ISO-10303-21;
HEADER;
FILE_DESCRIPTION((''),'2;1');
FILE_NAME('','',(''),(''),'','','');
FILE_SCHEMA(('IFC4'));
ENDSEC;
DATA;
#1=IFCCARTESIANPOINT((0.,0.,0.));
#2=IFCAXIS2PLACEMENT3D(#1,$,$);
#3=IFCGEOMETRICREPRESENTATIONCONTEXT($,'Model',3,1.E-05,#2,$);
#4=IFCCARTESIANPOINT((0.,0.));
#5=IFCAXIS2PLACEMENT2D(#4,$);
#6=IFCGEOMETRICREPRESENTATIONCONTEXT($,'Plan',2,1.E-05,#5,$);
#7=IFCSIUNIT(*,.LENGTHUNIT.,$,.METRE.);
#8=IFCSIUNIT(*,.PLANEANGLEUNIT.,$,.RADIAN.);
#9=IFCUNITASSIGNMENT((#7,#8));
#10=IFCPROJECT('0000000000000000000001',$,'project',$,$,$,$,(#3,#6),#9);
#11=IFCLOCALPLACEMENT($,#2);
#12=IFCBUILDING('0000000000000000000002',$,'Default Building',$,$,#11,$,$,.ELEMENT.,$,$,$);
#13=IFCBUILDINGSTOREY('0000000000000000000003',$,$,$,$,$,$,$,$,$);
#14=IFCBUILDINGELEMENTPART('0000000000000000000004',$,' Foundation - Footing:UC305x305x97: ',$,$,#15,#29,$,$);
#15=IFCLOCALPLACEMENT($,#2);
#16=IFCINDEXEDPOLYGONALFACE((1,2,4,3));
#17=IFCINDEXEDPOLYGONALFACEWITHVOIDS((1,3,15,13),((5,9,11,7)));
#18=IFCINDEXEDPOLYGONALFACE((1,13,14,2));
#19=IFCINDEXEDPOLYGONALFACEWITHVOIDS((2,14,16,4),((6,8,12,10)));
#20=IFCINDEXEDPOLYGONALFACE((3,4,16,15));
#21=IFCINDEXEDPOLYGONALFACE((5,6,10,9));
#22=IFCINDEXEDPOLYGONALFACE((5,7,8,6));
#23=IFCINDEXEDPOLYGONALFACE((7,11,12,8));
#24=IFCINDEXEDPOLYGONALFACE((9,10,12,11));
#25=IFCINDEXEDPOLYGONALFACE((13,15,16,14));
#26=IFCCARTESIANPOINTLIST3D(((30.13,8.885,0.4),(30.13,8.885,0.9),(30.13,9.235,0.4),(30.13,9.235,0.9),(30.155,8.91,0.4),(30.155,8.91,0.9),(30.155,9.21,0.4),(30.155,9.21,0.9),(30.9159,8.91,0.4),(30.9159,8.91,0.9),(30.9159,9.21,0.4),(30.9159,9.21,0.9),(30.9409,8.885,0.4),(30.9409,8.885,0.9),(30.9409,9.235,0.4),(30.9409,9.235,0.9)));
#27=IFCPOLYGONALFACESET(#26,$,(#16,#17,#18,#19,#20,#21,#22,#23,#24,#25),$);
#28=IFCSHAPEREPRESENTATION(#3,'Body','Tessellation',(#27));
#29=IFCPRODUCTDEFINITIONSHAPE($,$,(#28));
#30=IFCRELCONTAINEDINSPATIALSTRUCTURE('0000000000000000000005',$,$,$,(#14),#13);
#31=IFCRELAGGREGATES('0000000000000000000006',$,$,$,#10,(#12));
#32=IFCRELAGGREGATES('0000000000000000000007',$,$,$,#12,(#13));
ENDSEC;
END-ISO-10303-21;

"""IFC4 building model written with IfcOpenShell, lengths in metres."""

from ifc_helpers import new_model, si_unit, origin, origin_2d, place, context, project, spatial, polyline, outline, extrude, element, save


model = new_model("IFC4")

# Units and contexts
model_context = context("Model", 3, precision=1e-05, world=origin())
plan_context = context("Plan", 2, precision=1e-05, world=origin_2d())
ifc_project = project(units=[si_unit("LENGTHUNIT", "METRE"), si_unit("PLANEANGLEUNIT", "RADIAN")], contexts=[model_context, plan_context])

# Building, storey
building_placement = place(None, origin())
building = spatial("IfcBuilding", under=ifc_project, at=building_placement, Name="Default Building", CompositionType="ELEMENT")
storey = spatial("IfcBuildingStorey", under=building)

# Building element part, opening
building_element_part_1 = element("IfcBuildingElementPart", 1, inside=storey, Name=" Foundation - Footing:UC305x305x97: ", context=model_context, shape_type="SweptSolid", body=[
    extrude(outline(polyline([(30.13, 8.885, 0.4), (30.9409, 8.885, 0.4), (30.9409, 9.235, 0.4), (30.13, 9.235, 0.4), (30.13, 8.885, 0.4)])), None, (0.0, 0.0, 1.0), 0.5),
])
element("IfcOpeningElement", 2, inside=storey, cuts=building_element_part_1, context=model_context, shape_type="SweptSolid", body=[
    extrude(outline(polyline([(30.155, 8.91, 0.4), (30.9159, 8.91, 0.4), (30.9159, 9.21, 0.4), (30.155, 9.21, 0.4), (30.155, 8.91, 0.4)])), None, (0.0, 0.0, 1.0), 0.5),
])

save(model, "model.ifc")
